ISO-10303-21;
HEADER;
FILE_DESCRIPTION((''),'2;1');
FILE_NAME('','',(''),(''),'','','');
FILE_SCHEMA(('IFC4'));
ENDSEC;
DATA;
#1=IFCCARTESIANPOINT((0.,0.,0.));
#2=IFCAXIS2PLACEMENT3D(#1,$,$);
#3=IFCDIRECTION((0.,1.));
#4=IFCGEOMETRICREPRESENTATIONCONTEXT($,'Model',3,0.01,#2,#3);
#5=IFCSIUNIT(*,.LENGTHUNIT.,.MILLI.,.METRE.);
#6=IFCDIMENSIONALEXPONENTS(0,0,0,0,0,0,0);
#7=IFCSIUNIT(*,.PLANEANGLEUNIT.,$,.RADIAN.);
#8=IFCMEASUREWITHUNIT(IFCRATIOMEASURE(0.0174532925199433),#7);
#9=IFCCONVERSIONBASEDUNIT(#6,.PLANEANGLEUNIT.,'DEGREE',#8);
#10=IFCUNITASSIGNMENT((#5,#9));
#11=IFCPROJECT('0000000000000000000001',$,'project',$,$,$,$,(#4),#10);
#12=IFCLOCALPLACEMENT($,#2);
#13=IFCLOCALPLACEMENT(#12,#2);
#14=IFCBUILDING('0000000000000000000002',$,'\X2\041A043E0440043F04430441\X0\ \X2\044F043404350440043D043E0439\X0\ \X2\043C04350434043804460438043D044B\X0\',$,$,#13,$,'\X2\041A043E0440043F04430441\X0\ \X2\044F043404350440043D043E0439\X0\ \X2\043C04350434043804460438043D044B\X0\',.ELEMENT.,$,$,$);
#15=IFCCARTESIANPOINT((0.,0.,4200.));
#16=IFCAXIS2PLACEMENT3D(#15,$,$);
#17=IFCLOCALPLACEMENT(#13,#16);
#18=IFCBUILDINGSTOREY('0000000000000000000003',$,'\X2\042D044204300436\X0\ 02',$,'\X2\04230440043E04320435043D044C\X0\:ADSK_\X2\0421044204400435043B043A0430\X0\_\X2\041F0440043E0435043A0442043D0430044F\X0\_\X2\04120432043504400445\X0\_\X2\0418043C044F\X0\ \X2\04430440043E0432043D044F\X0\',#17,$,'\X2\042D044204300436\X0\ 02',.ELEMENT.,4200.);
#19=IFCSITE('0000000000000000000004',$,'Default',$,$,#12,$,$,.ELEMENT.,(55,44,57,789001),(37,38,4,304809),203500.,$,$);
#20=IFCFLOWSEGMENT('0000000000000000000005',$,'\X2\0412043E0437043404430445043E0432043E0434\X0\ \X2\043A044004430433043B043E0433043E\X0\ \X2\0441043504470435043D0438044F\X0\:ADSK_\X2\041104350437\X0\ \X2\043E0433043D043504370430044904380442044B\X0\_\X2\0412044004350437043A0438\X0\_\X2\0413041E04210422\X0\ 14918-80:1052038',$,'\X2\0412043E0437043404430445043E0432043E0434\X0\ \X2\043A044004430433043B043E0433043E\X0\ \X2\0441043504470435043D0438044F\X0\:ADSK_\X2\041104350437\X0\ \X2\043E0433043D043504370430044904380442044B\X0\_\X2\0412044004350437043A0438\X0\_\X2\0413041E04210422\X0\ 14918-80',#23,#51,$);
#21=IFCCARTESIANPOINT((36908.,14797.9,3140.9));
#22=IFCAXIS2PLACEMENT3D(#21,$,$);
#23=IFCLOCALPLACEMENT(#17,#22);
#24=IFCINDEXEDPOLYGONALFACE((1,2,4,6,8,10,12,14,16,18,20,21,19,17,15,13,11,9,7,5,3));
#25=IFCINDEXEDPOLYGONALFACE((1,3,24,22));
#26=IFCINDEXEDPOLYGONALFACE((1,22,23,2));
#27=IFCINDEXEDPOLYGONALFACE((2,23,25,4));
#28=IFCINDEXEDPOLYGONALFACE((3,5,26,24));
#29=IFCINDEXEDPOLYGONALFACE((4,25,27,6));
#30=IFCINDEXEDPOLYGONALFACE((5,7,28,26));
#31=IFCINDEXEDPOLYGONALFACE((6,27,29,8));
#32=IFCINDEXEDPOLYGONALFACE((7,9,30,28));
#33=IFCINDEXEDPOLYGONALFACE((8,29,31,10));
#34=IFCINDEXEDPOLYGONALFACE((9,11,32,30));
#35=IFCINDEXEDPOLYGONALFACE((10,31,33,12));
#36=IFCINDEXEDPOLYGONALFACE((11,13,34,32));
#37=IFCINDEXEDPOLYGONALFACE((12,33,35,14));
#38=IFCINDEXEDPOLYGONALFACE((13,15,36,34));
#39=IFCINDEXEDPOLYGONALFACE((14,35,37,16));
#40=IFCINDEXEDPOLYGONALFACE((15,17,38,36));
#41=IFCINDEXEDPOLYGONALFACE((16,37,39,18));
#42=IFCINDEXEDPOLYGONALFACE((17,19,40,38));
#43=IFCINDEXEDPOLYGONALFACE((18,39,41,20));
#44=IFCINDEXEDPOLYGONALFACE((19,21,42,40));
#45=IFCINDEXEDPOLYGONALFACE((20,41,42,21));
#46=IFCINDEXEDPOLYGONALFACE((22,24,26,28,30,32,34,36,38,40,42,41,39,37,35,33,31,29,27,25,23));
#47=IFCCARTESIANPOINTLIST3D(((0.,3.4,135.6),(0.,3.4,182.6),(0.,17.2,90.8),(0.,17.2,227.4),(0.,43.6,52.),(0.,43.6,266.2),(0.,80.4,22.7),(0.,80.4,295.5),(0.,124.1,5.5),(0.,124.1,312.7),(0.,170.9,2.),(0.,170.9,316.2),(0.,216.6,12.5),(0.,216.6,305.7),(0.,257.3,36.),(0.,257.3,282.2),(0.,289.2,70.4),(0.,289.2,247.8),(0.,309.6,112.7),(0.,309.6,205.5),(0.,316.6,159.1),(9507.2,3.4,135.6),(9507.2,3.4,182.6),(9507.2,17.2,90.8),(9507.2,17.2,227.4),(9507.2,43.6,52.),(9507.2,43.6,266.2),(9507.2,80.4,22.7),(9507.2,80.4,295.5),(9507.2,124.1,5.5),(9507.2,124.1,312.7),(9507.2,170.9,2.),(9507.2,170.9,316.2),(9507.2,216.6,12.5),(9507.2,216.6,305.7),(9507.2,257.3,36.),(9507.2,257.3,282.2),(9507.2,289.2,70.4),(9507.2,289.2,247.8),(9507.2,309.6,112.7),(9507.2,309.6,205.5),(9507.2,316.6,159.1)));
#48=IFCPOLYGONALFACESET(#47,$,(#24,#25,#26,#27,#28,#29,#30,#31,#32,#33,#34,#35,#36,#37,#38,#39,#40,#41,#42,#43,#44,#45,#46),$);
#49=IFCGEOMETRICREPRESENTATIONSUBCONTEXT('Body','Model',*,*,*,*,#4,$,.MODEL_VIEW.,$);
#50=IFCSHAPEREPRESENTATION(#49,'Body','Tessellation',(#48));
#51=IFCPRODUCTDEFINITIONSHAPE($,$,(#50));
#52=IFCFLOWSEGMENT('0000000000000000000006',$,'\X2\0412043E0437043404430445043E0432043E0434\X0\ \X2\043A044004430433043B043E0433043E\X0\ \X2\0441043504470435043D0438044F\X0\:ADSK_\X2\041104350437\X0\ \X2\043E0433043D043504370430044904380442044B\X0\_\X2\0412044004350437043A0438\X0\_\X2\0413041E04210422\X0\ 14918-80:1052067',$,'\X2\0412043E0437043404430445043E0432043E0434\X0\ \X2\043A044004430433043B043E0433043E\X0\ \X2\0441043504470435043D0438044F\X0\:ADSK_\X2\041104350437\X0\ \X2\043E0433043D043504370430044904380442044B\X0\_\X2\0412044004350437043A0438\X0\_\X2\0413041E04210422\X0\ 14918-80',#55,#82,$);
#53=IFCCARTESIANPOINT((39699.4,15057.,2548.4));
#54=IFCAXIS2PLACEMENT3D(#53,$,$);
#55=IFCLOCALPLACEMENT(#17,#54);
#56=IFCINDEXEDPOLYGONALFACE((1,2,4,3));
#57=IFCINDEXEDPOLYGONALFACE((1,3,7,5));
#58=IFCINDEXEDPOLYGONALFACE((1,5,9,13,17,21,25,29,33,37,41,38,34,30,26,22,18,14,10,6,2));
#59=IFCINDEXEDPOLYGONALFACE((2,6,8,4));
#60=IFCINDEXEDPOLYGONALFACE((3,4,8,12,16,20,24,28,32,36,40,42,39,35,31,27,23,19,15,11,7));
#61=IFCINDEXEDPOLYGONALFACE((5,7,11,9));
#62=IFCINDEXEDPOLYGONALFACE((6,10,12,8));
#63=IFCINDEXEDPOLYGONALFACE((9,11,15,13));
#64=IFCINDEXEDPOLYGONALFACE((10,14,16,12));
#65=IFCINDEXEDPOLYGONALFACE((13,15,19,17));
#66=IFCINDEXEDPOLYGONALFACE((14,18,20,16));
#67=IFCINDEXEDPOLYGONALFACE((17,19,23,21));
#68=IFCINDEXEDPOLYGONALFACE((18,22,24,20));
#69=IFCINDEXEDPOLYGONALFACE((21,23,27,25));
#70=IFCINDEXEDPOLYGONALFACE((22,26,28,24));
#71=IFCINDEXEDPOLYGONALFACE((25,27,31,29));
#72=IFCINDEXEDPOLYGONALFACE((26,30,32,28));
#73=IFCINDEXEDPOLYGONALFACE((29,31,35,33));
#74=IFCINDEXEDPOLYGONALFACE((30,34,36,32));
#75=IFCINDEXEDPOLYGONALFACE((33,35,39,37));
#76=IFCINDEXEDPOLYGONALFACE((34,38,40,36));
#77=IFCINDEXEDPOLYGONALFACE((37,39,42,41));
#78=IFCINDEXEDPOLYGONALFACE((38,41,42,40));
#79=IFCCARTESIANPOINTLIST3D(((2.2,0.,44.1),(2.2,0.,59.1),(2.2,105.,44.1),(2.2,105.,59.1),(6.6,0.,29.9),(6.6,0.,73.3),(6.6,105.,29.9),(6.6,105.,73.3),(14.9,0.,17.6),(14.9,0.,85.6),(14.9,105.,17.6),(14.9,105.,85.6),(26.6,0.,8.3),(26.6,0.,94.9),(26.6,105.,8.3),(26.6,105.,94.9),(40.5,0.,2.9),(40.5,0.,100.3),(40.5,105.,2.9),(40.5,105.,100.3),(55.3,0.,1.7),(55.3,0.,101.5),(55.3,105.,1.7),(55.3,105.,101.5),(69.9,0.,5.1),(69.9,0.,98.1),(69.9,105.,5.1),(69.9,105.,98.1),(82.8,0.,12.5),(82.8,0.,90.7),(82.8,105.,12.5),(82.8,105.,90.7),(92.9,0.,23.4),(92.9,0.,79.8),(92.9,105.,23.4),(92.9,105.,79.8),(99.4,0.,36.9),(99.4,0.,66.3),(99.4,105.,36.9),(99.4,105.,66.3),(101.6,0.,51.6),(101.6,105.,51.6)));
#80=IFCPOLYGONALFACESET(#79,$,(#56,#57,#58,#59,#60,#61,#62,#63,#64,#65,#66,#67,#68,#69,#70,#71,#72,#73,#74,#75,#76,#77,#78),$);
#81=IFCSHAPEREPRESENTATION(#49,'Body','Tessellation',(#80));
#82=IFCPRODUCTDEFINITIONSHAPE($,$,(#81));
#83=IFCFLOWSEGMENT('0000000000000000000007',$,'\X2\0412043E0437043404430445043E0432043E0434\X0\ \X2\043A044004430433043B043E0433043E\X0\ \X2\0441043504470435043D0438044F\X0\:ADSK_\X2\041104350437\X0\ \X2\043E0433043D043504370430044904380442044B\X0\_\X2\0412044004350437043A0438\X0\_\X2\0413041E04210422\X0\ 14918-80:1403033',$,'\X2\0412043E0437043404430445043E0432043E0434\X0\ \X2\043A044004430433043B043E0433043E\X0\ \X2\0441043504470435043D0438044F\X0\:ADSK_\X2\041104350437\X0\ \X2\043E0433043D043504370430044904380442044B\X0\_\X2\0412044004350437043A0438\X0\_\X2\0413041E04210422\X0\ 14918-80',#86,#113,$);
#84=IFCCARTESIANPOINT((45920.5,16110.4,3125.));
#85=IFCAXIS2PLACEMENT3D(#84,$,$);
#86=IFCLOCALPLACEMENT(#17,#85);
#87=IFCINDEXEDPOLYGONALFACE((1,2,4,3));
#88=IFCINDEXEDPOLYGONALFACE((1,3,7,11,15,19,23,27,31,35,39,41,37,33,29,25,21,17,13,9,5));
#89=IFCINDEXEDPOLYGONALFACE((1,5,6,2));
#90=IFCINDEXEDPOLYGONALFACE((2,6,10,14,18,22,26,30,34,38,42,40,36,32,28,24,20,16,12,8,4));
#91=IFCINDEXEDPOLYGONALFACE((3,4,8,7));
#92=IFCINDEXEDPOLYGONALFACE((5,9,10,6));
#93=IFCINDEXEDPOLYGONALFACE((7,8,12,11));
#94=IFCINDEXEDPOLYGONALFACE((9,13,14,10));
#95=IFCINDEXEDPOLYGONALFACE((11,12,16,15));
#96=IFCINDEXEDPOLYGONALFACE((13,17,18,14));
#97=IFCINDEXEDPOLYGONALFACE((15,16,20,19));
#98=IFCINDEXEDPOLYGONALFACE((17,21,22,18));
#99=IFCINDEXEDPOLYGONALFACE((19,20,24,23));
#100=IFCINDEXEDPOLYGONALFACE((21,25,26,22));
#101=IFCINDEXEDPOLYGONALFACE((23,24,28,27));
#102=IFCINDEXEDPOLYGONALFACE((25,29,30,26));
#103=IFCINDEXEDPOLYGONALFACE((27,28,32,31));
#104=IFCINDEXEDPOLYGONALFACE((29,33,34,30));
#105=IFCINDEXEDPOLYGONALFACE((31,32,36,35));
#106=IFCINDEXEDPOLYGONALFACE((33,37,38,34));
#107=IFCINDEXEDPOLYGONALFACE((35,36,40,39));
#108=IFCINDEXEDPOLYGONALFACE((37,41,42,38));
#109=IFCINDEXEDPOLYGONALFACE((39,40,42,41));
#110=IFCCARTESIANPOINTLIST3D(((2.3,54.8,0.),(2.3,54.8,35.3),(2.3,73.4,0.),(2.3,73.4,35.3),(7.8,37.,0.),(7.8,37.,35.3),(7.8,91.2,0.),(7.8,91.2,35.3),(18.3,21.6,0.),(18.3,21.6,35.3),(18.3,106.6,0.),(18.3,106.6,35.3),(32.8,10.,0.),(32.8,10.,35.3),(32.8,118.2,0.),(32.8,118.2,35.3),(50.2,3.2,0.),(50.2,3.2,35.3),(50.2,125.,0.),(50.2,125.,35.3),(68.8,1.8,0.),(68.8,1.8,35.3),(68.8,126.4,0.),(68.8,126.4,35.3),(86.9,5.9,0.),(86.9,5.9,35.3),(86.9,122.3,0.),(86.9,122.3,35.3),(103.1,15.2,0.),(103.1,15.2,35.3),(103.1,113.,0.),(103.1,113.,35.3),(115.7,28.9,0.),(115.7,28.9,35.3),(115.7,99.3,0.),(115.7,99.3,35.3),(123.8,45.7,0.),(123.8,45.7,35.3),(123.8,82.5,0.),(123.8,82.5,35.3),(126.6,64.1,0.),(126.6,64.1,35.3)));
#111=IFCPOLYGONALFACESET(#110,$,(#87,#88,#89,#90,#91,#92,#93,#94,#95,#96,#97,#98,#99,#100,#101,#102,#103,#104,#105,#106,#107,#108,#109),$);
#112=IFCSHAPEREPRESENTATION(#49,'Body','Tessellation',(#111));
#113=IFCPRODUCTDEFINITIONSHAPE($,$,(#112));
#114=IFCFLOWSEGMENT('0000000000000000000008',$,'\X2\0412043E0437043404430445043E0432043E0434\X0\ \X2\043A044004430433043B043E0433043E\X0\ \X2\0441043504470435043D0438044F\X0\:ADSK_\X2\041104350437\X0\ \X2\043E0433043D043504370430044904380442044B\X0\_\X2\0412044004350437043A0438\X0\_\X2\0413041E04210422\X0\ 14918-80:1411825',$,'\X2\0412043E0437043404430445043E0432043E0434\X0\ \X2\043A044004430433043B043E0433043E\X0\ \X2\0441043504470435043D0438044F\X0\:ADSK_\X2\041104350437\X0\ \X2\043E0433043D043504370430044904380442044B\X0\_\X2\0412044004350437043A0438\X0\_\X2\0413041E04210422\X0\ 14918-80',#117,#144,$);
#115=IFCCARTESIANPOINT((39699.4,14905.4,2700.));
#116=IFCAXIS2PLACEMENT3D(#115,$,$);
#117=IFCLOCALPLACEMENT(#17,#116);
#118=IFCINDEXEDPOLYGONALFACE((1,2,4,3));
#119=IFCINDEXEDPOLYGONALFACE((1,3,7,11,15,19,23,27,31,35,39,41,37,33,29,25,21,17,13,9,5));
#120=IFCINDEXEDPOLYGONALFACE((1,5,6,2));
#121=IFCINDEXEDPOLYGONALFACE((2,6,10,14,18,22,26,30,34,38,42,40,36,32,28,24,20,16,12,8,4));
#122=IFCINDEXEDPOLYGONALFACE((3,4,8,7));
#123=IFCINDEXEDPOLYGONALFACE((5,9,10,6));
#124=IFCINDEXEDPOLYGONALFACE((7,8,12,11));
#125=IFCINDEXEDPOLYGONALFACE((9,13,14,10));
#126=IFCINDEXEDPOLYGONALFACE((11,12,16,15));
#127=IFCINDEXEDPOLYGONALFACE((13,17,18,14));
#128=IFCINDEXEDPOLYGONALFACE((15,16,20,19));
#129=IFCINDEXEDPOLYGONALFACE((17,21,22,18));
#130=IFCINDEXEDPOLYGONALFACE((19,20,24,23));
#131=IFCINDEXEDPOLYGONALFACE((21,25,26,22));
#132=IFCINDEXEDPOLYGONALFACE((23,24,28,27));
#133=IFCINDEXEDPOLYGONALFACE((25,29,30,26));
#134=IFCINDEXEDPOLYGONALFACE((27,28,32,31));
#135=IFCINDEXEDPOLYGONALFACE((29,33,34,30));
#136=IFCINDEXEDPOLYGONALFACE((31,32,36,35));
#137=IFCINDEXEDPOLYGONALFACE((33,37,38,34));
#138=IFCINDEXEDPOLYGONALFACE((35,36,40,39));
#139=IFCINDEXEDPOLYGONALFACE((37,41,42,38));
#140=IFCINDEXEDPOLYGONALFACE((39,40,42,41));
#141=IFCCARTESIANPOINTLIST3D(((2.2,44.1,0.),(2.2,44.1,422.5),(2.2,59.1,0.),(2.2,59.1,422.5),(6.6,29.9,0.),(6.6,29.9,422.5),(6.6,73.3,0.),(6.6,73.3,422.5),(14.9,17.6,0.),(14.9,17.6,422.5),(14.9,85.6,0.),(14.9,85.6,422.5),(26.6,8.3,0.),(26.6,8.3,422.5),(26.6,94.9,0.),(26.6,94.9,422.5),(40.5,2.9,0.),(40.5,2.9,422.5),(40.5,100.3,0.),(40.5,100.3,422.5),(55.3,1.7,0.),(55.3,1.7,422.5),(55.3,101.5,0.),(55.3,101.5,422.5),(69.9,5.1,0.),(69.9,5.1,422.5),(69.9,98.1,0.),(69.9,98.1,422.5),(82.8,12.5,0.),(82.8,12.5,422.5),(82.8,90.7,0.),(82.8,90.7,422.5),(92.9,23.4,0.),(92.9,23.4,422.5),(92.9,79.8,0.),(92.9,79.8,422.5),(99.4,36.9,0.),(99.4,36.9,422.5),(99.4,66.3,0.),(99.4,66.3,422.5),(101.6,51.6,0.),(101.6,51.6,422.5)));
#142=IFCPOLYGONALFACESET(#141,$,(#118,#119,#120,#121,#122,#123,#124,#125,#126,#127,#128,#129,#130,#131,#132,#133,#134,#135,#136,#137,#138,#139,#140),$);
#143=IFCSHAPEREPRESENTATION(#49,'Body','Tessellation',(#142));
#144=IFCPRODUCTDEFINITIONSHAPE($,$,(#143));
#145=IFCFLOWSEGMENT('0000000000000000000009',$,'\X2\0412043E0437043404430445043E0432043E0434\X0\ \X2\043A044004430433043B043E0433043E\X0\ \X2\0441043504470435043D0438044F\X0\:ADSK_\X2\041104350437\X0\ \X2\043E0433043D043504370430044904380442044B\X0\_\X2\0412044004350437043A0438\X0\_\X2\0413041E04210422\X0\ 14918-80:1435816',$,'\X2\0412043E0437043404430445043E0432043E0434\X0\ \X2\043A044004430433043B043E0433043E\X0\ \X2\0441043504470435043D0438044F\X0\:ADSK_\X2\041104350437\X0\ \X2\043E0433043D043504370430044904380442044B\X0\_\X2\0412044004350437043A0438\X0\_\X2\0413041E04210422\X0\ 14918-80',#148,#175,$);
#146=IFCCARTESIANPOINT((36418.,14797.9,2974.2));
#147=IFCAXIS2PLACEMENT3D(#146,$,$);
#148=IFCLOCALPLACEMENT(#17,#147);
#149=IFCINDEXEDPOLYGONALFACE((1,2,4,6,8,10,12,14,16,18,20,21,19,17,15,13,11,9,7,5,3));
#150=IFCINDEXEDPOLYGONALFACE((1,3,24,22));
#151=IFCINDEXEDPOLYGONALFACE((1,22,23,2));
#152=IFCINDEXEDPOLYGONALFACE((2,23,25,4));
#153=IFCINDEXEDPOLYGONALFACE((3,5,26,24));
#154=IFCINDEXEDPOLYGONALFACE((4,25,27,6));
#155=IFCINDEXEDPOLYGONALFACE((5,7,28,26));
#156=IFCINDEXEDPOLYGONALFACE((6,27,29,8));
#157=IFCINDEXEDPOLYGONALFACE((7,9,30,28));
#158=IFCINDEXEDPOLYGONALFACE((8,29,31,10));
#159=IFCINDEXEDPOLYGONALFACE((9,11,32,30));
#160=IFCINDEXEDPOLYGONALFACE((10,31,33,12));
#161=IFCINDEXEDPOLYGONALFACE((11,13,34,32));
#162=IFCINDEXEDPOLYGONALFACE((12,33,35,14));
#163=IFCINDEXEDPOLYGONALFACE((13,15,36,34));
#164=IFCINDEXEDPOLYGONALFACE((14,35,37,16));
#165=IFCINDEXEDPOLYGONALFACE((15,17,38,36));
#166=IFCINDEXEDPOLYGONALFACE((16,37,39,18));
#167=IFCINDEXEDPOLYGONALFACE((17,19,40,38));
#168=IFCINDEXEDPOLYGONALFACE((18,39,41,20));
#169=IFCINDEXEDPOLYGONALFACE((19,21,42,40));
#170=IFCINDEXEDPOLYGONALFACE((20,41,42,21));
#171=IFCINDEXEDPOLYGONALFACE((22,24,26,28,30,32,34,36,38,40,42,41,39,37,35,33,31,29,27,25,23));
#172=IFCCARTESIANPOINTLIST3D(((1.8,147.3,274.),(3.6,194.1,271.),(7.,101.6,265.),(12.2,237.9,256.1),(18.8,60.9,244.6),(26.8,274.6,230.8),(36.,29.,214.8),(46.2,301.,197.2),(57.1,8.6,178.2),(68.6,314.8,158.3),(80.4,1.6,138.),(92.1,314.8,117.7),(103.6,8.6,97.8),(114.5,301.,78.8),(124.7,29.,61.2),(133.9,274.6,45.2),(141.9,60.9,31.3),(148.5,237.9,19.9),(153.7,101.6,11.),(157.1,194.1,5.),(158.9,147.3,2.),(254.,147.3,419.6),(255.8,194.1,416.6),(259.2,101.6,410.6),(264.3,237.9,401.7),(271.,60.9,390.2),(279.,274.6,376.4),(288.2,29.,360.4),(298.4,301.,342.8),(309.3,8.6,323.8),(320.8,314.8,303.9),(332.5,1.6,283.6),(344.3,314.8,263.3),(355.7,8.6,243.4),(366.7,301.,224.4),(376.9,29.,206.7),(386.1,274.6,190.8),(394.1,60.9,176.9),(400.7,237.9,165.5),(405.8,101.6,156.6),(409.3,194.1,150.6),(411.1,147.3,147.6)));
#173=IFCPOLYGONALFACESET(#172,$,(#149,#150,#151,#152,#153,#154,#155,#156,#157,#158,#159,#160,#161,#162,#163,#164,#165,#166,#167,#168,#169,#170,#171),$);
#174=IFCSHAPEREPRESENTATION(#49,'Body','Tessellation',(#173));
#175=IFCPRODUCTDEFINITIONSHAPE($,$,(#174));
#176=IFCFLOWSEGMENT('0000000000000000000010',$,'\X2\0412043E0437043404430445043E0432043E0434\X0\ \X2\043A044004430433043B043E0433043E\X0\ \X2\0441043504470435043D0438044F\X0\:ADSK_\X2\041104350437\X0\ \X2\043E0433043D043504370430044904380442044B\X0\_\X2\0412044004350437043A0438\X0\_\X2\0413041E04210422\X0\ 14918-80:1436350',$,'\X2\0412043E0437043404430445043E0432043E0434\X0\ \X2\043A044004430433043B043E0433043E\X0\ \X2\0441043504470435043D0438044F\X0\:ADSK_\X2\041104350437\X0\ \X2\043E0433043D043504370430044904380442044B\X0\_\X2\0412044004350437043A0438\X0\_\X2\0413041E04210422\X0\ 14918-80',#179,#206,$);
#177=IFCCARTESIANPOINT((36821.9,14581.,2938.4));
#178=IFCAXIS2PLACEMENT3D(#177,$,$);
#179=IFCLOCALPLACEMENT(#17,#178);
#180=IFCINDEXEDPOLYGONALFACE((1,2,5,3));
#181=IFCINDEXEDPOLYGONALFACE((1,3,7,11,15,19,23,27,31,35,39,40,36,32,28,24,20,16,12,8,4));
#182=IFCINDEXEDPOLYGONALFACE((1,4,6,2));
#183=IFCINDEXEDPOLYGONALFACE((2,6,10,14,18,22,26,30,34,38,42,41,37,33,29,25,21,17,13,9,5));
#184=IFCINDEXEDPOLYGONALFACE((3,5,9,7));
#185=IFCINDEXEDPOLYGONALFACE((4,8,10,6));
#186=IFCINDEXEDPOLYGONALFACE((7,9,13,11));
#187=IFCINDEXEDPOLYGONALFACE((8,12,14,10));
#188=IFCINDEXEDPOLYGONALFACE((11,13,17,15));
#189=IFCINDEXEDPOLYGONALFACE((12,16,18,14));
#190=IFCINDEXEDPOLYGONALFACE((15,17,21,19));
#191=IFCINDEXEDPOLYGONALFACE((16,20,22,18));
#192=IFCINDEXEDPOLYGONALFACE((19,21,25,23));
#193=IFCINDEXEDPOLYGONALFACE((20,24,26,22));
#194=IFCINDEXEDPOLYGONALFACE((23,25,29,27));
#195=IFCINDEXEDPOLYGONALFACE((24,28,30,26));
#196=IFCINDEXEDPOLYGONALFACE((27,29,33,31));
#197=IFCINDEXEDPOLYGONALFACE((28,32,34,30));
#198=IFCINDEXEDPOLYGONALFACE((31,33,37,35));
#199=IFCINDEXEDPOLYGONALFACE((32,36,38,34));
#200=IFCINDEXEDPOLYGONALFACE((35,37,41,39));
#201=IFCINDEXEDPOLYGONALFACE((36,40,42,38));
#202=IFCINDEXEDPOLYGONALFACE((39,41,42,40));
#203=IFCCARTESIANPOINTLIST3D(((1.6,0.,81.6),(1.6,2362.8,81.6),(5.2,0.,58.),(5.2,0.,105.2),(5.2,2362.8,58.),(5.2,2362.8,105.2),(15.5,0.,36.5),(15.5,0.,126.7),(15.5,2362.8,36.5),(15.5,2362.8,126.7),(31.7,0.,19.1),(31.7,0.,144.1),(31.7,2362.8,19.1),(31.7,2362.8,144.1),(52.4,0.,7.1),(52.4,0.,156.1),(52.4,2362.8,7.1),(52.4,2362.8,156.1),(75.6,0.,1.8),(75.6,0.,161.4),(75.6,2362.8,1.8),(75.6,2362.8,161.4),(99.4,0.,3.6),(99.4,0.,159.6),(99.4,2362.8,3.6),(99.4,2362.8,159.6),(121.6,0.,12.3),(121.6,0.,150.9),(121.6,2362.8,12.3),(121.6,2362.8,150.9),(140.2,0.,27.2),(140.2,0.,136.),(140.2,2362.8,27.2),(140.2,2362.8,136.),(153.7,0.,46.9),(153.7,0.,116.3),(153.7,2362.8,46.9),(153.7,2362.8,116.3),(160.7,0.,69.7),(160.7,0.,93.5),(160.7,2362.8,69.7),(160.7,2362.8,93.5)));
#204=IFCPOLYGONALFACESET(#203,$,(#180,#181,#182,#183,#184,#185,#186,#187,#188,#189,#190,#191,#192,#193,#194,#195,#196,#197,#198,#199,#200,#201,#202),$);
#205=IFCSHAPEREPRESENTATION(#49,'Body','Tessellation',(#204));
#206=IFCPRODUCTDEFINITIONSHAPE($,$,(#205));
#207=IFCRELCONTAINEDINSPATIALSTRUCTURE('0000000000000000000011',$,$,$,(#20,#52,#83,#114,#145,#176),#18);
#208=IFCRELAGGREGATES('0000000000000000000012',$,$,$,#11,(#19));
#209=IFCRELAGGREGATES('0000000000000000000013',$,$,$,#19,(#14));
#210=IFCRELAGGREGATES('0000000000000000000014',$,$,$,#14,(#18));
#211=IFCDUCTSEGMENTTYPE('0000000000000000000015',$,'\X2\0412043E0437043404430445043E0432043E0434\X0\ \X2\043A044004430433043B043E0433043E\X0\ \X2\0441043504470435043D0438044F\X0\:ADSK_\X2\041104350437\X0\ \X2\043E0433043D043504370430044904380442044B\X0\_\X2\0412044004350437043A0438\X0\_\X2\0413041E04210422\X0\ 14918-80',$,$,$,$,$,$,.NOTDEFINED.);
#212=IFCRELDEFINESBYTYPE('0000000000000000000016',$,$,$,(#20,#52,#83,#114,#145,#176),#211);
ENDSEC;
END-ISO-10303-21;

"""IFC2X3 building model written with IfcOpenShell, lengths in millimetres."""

from ifc_helpers import new_model, entity, si_unit, converted_unit, direction, frame, origin, origin_2d_with_axis, place, context, subcontext, project, spatial, circle, extrude, type_object, element, save


model = new_model("IFC2X3")

# Units and contexts
model_context = context("Model", 3, precision=0.01, world=origin(), true_north=direction((0.0, 1.0)))
body_context = subcontext(model_context, "Body", "Model", "MODEL_VIEW")
ifc_project = project(units=[si_unit("LENGTHUNIT", "METRE", prefix="MILLI"), converted_unit("PLANEANGLEUNIT", "DEGREE", entity("IfcRatioMeasure", 0.0174532925199433), si_unit("PLANEANGLEUNIT", "RADIAN"), dimensions=[0, 0, 0, 0, 0, 0, 0])], contexts=[model_context])

# Site, building, storey
site_placement = place(None, origin())
site = spatial("IfcSite", under=ifc_project, at=site_placement, Name="Default", CompositionType="ELEMENT", RefLatitude=(55, 44, 57, 789001), RefLongitude=(37, 38, 4, 304809), RefElevation=203500.0)
building_placement = place(site_placement, origin())
building = spatial("IfcBuilding", under=site, at=building_placement, Name="Корпус ядерной медицины", LongName="Корпус ядерной медицины", CompositionType="ELEMENT")
storey_placement = place(building_placement, frame((0.0, 0.0, 4200.0)))
storey = spatial("IfcBuildingStorey", under=building, at=storey_placement, Name="Этаж 02", ObjectType="Уровень:ADSK_Стрелка_Проектная_Вверх_Имя уровня", LongName="Этаж 02", CompositionType="ELEMENT", Elevation=4200.0)

# Flow segments
duct_segment_type = type_object("IfcDuctSegmentType", Name="Воздуховод круглого сечения:ADSK_Без огнезащиты_Врезки_ГОСТ 14918-80", PredefinedType="NOTDEFINED")
flow_segment_1_placement = place(storey_placement, frame((36908.0, 14797.9, 3140.9)))
element("IfcFlowSegment", 1, at=flow_segment_1_placement, inside=storey, type_object=duct_segment_type, Name="Воздуховод круглого сечения:ADSK_Без огнезащиты_Врезки_ГОСТ 14918-80:1052038", ObjectType="Воздуховод круглого сечения:ADSK_Без огнезащиты_Врезки_ГОСТ 14918-80", context=body_context, shape_type="SweptSolid", body=[
    extrude(circle(Radius=157.5, at=origin_2d_with_axis()), frame((0.0, 159.1, 159.1), z_axis=(1.0, 0.0, 0.0), x_axis=(0.0, 1.0, 0.0)), (0.0, 0.0, 1.0), 9507.2),
])
flow_segment_2_placement = place(storey_placement, frame((39699.4, 15057.0, 2548.4)))
element("IfcFlowSegment", 2, at=flow_segment_2_placement, inside=storey, type_object=duct_segment_type, Name="Воздуховод круглого сечения:ADSK_Без огнезащиты_Врезки_ГОСТ 14918-80:1052067", ObjectType="Воздуховод круглого сечения:ADSK_Без огнезащиты_Врезки_ГОСТ 14918-80", context=body_context, shape_type="SweptSolid", body=[
    extrude(circle(Radius=50.0, at=origin_2d_with_axis()), frame((51.6, 0.0, 51.6), z_axis=(0.0, 1.0, 0.0), x_axis=(1.0, 0.0, 0.0)), (0.0, 0.0, 1.0), 105.0),
])
flow_segment_3_placement = place(storey_placement, frame((45920.5, 16110.4, 3125.0)))
element("IfcFlowSegment", 3, at=flow_segment_3_placement, inside=storey, type_object=duct_segment_type, Name="Воздуховод круглого сечения:ADSK_Без огнезащиты_Врезки_ГОСТ 14918-80:1403033", ObjectType="Воздуховод круглого сечения:ADSK_Без огнезащиты_Врезки_ГОСТ 14918-80", context=body_context, shape_type="SweptSolid", body=[
    extrude(circle(Radius=62.5, at=origin_2d_with_axis()), frame((64.1, 64.1, 0.0)), (0.0, 0.0, 1.0), 35.3),
])
flow_segment_4_placement = place(storey_placement, frame((39699.4, 14905.4, 2700.0)))
element("IfcFlowSegment", 4, at=flow_segment_4_placement, inside=storey, type_object=duct_segment_type, Name="Воздуховод круглого сечения:ADSK_Без огнезащиты_Врезки_ГОСТ 14918-80:1411825", ObjectType="Воздуховод круглого сечения:ADSK_Без огнезащиты_Врезки_ГОСТ 14918-80", context=body_context, shape_type="SweptSolid", body=[
    extrude(circle(Radius=50.0, at=origin_2d_with_axis()), frame((51.6, 51.6, 0.0)), (0.0, 0.0, 1.0), 422.5),
])
flow_segment_5_placement = place(storey_placement, frame((36418.0, 14797.9, 2974.2)))
element("IfcFlowSegment", 5, at=flow_segment_5_placement, inside=storey, type_object=duct_segment_type, Name="Воздуховод круглого сечения:ADSK_Без огнезащиты_Врезки_ГОСТ 14918-80:1435816", ObjectType="Воздуховод круглого сечения:ADSK_Без огнезащиты_Врезки_ГОСТ 14918-80", context=body_context, shape_type="SweptSolid", body=[
    extrude(circle(Radius=157.5, at=origin_2d_with_axis()), frame((80.3, 159.1, 138.0), z_axis=(0.866025, 0.0, 0.5), x_axis=(0.0, -1.0, 0.0)), (0.0, 0.0, 1.0), 291.2),
])
flow_segment_6_placement = place(storey_placement, frame((36821.9, 14581.0, 2938.4)))
element("IfcFlowSegment", 6, at=flow_segment_6_placement, inside=storey, type_object=duct_segment_type, Name="Воздуховод круглого сечения:ADSK_Без огнезащиты_Врезки_ГОСТ 14918-80:1436350", ObjectType="Воздуховод круглого сечения:ADSK_Без огнезащиты_Врезки_ГОСТ 14918-80", context=body_context, shape_type="SweptSolid", body=[
    extrude(circle(Radius=80.0, at=origin_2d_with_axis()), frame((81.6, 0.0, 81.6), z_axis=(0.0, 1.0, 0.0), x_axis=(-1.0, 0.0, 0.0)), (0.0, 0.0, 1.0), 2362.8),
])

save(model, "model.ifc")
